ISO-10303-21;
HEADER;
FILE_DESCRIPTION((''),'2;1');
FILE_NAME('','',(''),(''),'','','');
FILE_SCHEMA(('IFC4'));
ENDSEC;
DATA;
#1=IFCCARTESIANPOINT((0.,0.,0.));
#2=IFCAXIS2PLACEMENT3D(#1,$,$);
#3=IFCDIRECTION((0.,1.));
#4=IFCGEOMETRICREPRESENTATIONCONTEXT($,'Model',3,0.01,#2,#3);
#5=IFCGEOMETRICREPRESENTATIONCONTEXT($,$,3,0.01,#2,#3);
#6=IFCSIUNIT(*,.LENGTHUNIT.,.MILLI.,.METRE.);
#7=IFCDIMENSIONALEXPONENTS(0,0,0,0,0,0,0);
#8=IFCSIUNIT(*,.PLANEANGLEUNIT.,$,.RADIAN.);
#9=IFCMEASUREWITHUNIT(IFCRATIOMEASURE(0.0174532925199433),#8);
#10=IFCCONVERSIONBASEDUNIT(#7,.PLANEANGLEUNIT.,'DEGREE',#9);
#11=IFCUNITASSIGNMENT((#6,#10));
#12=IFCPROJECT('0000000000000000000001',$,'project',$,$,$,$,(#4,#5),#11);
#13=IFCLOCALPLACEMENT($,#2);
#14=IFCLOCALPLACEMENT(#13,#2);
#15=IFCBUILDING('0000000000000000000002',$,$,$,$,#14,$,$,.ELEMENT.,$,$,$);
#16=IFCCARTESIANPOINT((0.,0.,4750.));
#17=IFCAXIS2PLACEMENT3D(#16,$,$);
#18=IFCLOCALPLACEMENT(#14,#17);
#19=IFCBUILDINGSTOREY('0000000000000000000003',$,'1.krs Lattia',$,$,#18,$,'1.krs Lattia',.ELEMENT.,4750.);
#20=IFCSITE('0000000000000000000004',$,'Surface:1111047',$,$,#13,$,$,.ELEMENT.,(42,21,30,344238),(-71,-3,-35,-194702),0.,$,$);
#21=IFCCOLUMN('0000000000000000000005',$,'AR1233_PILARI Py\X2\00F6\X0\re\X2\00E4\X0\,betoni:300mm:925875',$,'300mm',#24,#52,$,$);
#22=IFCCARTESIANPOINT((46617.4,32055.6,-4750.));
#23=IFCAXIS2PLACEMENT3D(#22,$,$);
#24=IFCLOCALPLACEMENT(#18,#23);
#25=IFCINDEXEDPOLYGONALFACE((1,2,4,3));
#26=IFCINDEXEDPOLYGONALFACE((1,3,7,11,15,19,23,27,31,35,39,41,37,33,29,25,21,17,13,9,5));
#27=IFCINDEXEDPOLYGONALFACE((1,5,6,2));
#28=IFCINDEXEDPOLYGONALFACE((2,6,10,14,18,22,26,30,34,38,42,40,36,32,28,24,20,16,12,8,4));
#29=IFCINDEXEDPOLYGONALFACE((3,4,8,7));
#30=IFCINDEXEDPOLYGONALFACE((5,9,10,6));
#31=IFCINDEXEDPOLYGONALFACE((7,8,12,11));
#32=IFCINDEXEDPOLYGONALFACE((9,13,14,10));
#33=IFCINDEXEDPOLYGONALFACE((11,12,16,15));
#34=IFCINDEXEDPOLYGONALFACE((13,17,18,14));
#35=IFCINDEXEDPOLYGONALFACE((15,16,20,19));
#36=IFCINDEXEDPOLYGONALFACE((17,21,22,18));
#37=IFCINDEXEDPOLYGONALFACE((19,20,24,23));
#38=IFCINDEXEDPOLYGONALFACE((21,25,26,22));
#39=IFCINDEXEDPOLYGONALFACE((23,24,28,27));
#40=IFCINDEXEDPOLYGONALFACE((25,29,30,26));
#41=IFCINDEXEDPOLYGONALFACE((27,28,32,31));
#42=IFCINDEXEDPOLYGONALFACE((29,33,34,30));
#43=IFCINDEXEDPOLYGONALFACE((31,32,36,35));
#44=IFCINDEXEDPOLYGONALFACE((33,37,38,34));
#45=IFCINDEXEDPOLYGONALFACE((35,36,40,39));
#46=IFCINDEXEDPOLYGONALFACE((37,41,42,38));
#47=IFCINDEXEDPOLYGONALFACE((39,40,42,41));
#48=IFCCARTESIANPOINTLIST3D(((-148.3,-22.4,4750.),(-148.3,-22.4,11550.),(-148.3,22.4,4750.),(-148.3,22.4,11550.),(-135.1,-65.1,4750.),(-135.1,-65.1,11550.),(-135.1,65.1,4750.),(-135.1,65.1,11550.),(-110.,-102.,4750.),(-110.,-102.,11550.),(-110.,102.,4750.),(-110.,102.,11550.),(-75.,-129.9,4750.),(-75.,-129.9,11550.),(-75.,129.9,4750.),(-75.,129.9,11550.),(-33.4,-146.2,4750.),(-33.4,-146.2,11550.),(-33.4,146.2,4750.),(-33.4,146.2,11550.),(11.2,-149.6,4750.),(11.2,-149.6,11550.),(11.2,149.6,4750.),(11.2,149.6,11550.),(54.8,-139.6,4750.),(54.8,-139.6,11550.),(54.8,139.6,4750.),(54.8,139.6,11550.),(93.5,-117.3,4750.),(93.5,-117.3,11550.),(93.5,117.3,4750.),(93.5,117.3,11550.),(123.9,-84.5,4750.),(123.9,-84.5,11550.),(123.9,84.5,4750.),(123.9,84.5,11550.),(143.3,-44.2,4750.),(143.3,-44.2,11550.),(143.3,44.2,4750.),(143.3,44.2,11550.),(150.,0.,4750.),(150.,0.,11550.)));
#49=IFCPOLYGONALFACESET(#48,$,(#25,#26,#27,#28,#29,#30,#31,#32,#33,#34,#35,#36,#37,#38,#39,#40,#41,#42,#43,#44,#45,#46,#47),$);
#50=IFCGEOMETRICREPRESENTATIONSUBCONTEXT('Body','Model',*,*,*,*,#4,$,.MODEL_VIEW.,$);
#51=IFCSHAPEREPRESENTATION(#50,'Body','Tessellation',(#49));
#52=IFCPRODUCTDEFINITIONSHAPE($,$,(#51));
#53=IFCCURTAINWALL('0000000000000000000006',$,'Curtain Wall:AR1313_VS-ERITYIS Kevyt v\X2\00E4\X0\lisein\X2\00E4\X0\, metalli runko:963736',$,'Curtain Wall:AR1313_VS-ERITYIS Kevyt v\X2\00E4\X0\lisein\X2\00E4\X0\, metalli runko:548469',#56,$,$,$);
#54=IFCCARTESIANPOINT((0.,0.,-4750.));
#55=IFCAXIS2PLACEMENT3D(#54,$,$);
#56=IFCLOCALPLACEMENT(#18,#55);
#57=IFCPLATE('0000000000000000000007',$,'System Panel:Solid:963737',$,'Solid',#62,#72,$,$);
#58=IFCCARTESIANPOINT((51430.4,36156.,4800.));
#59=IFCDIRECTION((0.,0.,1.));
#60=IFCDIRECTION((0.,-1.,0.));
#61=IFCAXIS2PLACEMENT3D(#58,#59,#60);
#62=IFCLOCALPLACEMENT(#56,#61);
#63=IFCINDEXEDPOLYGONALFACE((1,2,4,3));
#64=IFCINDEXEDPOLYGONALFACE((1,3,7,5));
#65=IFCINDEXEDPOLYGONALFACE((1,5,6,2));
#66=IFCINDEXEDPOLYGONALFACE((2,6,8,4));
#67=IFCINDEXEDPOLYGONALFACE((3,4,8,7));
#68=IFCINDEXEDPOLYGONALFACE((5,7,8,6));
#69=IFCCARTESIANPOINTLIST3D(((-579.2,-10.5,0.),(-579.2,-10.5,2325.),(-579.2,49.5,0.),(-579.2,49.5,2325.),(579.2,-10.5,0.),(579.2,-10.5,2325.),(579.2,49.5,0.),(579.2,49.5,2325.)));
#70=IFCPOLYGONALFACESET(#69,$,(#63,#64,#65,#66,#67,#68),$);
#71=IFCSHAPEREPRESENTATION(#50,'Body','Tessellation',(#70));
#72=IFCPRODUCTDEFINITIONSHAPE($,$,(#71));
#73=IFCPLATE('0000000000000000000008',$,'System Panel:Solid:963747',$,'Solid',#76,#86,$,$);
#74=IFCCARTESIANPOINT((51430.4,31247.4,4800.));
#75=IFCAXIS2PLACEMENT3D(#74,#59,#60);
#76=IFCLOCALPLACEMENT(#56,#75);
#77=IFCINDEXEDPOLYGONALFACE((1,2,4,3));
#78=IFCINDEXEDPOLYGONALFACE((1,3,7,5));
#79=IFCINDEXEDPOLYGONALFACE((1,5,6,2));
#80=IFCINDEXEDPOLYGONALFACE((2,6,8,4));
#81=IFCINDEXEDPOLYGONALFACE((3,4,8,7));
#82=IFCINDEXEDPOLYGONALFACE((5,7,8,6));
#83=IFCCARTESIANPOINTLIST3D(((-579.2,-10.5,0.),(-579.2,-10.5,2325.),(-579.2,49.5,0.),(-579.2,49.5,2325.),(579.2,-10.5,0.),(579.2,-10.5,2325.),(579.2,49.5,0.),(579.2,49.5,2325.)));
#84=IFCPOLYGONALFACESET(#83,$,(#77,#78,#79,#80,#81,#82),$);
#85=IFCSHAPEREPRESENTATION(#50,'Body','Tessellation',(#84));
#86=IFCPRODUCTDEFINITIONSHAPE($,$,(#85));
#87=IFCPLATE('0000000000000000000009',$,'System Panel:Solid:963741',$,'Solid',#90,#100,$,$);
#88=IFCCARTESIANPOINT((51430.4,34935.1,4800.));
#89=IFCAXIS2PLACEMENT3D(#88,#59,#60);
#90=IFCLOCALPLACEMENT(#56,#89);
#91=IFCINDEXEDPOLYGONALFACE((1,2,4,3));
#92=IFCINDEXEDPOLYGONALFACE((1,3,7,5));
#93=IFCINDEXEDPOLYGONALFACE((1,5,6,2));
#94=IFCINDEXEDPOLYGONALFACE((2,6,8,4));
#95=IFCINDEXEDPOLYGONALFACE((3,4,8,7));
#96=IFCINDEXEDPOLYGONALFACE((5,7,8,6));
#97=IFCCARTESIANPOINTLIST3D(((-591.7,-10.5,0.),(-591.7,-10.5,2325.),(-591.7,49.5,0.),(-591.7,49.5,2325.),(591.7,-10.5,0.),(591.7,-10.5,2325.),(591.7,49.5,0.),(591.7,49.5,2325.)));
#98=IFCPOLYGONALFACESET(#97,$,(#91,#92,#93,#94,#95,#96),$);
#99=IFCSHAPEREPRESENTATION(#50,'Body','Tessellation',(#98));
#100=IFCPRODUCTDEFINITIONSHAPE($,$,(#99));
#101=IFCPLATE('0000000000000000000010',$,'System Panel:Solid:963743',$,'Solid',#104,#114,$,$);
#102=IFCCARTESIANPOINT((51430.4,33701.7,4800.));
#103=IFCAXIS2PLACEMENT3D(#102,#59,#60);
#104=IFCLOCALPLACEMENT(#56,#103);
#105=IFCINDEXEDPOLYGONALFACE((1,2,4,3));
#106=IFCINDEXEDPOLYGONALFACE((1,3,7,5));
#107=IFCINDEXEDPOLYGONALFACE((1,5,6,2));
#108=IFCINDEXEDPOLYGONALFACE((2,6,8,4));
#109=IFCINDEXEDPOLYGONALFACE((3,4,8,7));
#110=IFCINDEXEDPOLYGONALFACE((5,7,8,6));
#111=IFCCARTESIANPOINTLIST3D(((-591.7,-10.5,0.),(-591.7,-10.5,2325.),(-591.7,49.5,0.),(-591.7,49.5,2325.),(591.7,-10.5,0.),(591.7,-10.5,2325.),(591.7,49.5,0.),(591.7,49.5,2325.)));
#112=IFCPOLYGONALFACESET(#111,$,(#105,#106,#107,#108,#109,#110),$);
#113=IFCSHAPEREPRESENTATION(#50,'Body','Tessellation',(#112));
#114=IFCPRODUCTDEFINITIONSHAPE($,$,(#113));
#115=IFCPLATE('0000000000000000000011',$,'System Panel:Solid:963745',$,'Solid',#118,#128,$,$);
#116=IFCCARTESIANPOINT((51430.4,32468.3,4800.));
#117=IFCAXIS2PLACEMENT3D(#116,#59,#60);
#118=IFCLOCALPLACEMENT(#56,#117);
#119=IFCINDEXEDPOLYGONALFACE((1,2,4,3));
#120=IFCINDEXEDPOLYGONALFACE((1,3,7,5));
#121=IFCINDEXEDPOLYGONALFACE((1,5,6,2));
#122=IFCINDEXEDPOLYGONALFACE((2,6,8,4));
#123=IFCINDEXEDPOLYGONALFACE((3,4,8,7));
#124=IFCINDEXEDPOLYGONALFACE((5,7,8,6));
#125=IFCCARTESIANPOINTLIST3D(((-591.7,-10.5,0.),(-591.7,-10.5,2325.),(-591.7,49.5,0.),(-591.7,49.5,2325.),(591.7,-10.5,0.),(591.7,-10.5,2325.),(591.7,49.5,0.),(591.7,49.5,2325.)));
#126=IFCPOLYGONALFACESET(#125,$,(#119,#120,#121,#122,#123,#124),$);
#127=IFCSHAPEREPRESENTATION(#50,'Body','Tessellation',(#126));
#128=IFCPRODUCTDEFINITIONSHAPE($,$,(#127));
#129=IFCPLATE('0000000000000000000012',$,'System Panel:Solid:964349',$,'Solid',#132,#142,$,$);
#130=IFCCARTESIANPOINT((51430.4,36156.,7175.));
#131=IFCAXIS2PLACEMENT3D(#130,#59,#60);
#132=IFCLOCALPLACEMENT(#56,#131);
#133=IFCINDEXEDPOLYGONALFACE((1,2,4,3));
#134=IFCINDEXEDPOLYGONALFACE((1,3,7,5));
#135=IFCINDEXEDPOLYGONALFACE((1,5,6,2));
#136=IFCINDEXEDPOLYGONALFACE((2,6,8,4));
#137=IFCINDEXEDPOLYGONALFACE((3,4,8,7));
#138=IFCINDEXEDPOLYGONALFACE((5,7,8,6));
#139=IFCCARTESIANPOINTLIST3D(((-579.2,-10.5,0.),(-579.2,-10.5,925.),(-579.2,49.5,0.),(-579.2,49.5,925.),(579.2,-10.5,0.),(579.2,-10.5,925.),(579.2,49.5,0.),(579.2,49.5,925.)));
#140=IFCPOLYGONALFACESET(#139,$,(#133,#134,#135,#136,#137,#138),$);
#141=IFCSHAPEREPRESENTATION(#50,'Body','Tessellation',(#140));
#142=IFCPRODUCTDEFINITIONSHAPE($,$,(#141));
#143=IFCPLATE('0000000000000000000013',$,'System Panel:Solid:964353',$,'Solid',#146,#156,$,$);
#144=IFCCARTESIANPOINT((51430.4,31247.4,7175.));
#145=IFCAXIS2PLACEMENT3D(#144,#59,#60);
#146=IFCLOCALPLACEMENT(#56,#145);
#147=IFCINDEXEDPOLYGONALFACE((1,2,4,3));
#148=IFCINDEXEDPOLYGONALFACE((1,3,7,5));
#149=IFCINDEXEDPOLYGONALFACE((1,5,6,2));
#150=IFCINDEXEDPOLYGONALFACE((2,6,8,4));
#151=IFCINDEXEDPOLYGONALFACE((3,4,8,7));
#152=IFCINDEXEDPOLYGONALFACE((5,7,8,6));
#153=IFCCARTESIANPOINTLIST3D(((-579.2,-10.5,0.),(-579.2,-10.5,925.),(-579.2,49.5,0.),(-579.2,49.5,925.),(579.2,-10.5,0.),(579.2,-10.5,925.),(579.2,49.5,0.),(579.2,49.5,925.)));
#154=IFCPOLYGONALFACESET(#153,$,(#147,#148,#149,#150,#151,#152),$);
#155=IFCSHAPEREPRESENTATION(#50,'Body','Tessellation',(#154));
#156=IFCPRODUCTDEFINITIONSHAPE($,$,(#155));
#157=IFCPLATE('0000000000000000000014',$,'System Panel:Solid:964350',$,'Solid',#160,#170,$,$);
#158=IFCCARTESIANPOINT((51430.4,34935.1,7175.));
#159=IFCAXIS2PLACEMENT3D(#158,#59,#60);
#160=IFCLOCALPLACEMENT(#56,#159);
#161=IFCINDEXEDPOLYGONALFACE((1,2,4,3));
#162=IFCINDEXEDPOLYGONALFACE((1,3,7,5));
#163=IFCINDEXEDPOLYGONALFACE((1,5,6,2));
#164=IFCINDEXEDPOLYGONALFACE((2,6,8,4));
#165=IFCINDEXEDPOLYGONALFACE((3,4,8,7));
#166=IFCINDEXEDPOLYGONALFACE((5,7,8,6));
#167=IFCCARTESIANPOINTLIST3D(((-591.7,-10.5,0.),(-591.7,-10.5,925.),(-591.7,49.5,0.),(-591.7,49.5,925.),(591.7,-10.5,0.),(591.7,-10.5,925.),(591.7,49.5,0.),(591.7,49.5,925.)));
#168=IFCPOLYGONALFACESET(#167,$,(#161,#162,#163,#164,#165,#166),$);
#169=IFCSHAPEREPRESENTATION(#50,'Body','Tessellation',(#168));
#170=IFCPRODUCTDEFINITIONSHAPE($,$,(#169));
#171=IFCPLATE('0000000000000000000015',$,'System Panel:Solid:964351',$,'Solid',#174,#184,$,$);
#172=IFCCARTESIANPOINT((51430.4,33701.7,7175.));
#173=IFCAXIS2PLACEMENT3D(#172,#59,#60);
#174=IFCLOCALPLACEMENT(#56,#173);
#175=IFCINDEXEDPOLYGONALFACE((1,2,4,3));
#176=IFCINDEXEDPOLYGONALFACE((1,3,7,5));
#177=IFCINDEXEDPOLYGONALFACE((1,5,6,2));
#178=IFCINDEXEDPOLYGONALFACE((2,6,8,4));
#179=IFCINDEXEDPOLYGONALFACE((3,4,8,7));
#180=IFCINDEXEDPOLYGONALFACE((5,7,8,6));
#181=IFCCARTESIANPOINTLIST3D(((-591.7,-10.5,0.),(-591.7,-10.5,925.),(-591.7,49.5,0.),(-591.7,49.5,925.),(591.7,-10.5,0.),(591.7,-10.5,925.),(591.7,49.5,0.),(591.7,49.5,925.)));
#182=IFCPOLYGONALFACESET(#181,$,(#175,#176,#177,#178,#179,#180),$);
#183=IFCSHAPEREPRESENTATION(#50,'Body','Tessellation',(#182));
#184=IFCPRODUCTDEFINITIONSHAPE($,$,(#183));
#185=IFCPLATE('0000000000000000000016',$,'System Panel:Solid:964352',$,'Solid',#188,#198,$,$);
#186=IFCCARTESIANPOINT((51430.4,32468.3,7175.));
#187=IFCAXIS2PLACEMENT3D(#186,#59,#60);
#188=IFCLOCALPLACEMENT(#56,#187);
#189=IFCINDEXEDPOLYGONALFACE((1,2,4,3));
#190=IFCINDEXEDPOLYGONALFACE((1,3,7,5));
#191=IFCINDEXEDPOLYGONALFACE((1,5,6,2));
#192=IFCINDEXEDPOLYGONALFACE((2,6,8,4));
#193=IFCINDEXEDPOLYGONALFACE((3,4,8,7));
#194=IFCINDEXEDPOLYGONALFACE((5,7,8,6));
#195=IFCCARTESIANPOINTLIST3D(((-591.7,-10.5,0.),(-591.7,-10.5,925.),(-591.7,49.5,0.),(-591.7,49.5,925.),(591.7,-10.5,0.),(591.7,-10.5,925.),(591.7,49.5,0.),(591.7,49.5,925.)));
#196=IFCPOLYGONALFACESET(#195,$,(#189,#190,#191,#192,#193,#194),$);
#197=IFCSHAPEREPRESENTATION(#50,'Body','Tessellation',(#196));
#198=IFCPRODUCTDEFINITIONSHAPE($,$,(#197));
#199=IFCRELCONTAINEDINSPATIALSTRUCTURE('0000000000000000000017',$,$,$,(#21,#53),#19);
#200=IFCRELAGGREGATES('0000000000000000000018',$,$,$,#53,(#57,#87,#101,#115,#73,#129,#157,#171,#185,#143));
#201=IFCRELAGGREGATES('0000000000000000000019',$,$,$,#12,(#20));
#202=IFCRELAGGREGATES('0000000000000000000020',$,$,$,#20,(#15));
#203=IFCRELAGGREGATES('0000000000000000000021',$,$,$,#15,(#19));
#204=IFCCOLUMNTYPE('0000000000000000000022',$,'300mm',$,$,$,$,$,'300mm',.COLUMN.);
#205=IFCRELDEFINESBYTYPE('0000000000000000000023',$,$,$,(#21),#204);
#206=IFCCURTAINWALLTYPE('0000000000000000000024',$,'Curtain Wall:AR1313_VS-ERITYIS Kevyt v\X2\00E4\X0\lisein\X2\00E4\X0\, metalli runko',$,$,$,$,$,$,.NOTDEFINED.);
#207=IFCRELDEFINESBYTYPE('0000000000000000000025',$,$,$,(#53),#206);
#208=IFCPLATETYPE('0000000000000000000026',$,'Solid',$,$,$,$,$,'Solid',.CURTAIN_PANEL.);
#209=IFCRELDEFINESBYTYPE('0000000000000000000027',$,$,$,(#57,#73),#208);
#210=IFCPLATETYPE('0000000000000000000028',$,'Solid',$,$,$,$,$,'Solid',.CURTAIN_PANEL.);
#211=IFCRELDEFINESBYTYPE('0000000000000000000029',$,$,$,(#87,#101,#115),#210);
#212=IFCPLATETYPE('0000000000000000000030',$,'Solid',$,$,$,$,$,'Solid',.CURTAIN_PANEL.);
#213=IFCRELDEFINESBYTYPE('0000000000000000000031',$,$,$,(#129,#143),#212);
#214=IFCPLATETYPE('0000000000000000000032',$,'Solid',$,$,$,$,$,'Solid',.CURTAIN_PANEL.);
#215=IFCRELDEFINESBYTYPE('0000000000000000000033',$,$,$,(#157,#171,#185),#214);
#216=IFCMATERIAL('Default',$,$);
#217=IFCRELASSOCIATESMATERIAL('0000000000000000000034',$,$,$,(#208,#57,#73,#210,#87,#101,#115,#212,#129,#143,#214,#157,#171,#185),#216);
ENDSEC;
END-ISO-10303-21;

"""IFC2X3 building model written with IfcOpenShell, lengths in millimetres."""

from ifc_helpers import new_model, entity, si_unit, converted_unit, direction, frame, frame_2d, origin, origin_2d_with_axis, place, context, subcontext, project, spatial, rectangle, circle, extrude, source, transform, mapped, material, type_object, type_shapes, element, aggregate, save


model = new_model("IFC2X3")

# Units and contexts
model_context = context("Model", 3, precision=0.01, world=origin(), true_north=direction((0.0, 1.0)))
context_of_model = context(None, 3, precision=0.01, world=origin(), true_north=direction((0.0, 1.0)))
body_context = subcontext(model_context, "Body", "Model", "MODEL_VIEW")
ifc_project = project(units=[si_unit("LENGTHUNIT", "METRE", prefix="MILLI"), converted_unit("PLANEANGLEUNIT", "DEGREE", entity("IfcRatioMeasure", 0.0174532925199433), si_unit("PLANEANGLEUNIT", "RADIAN"), dimensions=[0, 0, 0, 0, 0, 0, 0])], contexts=[model_context, context_of_model])

# Site, building, storey
site_placement = place(None, origin())
site = spatial("IfcSite", under=ifc_project, at=site_placement, Name="Surface:1111047", CompositionType="ELEMENT", RefLatitude=(42, 21, 30, 344238), RefLongitude=(-71, -3, -35, -194702), RefElevation=0.0)
building_placement = place(site_placement, origin())
building = spatial("IfcBuilding", under=site, at=building_placement, CompositionType="ELEMENT")
storey_placement = place(building_placement, frame((0.0, 0.0, 4750.0)))
storey = spatial("IfcBuildingStorey", under=building, at=storey_placement, Name="1.krs Lattia", LongName="1.krs Lattia", CompositionType="ELEMENT", Elevation=4750.0)

# Column
column_type = type_object("IfcColumnType", Name="300mm", ElementType="300mm", PredefinedType="COLUMN")
shared_shape_1 = source(origin(), body_context, "Body", "SweptSolid", [
    extrude(circle(Radius=150.0, at=frame_2d((0.0, 0.0), x_axis=(1.0, 0.0))), frame((0.0, 0.0, 4750.0)), (0.0, 0.0, 1.0), 6800.0),
])
type_shapes(column_type, [shared_shape_1])
column_placement = place(storey_placement, frame((46617.4, 32055.6, -4750.0)))
element("IfcColumn", 1, at=column_placement, inside=storey, type_object=column_type, Name="AR1233_PILARI Pyöreä,betoni:300mm:925875", ObjectType="300mm", context=body_context, shape_type="MappedRepresentation", body=[
    mapped(shared_shape_1, transform((0.0, 0.0, 0.0), scale=1.0)),
])

# Curtain wall, plates
curtain_wall_type = type_object("IfcCurtainWallType", Name="Curtain Wall:AR1313_VS-ERITYIS Kevyt väliseinä, metalli runko", PredefinedType="NOTDEFINED")
curtain_wall_placement = place(storey_placement, frame((0.0, 0.0, -4750.0)))
curtain_wall = element("IfcCurtainWall", 2, at=curtain_wall_placement, inside=storey, type_object=curtain_wall_type, Name="Curtain Wall:AR1313_VS-ERITYIS Kevyt väliseinä, metalli runko:963736", ObjectType="Curtain Wall:AR1313_VS-ERITYIS Kevyt väliseinä, metalli runko:548469")
ifc_material_1 = material(Name="Default")
plate_type_1 = type_object("IfcPlateType", Name="Solid", ElementType="Solid", PredefinedType="CURTAIN_PANEL", material=ifc_material_1)
shared_shape_2 = source(origin(), body_context, "Body", "SweptSolid", [
    extrude(rectangle(XDim=60.0, YDim=1158.4, at=origin_2d_with_axis()), frame((0.0, 19.5, 0.0), z_axis=(0.0, 0.0, 1.0), x_axis=(0.0, 1.0, 0.0)), (0.0, 0.0, 1.0), 2325.0),
])
type_shapes(plate_type_1, [shared_shape_2])
plate_1_placement = place(curtain_wall_placement, frame((51430.4, 36156.0, 4800.0), z_axis=(0.0, 0.0, 1.0), x_axis=(0.0, -1.0, 0.0)))
plate_1 = element("IfcPlate", 3, at=plate_1_placement, type_object=plate_type_1, material=ifc_material_1, Name="System Panel:Solid:963737", ObjectType="Solid", context=body_context, shape_type="MappedRepresentation", body=[
    mapped(shared_shape_2, transform((0.0, 0.0, 0.0), scale=1.0)),
])
plate_2_placement = place(curtain_wall_placement, frame((51430.4, 31247.4, 4800.0), z_axis=(0.0, 0.0, 1.0), x_axis=(0.0, -1.0, 0.0)))
plate_2 = element("IfcPlate", 4, at=plate_2_placement, type_object=plate_type_1, material=ifc_material_1, Name="System Panel:Solid:963747", ObjectType="Solid", context=body_context, shape_type="MappedRepresentation", body=[
    mapped(shared_shape_2, transform((0.0, 0.0, 0.0), scale=1.0)),
])
plate_type_2 = type_object("IfcPlateType", Name="Solid", ElementType="Solid", PredefinedType="CURTAIN_PANEL", material=ifc_material_1)
shared_shape_3 = source(origin(), body_context, "Body", "SweptSolid", [
    extrude(rectangle(XDim=60.0, YDim=1183.4, at=origin_2d_with_axis()), frame((0.0, 19.5, 0.0), z_axis=(0.0, 0.0, 1.0), x_axis=(0.0, 1.0, 0.0)), (0.0, 0.0, 1.0), 2325.0),
])
type_shapes(plate_type_2, [shared_shape_3])
plate_3_placement = place(curtain_wall_placement, frame((51430.4, 34935.1, 4800.0), z_axis=(0.0, 0.0, 1.0), x_axis=(0.0, -1.0, 0.0)))
plate_3 = element("IfcPlate", 5, at=plate_3_placement, type_object=plate_type_2, material=ifc_material_1, Name="System Panel:Solid:963741", ObjectType="Solid", context=body_context, shape_type="MappedRepresentation", body=[
    mapped(shared_shape_3, transform((0.0, 0.0, 0.0), scale=1.0)),
])
plate_4_placement = place(curtain_wall_placement, frame((51430.4, 33701.7, 4800.0), z_axis=(0.0, 0.0, 1.0), x_axis=(0.0, -1.0, 0.0)))
plate_4 = element("IfcPlate", 6, at=plate_4_placement, type_object=plate_type_2, material=ifc_material_1, Name="System Panel:Solid:963743", ObjectType="Solid", context=body_context, shape_type="MappedRepresentation", body=[
    mapped(shared_shape_3, transform((0.0, 0.0, 0.0), scale=1.0)),
])
plate_5_placement = place(curtain_wall_placement, frame((51430.4, 32468.3, 4800.0), z_axis=(0.0, 0.0, 1.0), x_axis=(0.0, -1.0, 0.0)))
plate_5 = element("IfcPlate", 7, at=plate_5_placement, type_object=plate_type_2, material=ifc_material_1, Name="System Panel:Solid:963745", ObjectType="Solid", context=body_context, shape_type="MappedRepresentation", body=[
    mapped(shared_shape_3, transform((0.0, 0.0, 0.0), scale=1.0)),
])
plate_type_3 = type_object("IfcPlateType", Name="Solid", ElementType="Solid", PredefinedType="CURTAIN_PANEL", material=ifc_material_1)
shared_shape_4 = source(origin(), body_context, "Body", "SweptSolid", [
    extrude(rectangle(XDim=60.0, YDim=1158.4, at=origin_2d_with_axis()), frame((0.0, 19.5, 0.0), z_axis=(0.0, 0.0, 1.0), x_axis=(0.0, 1.0, 0.0)), (0.0, 0.0, 1.0), 925.0),
])
type_shapes(plate_type_3, [shared_shape_4])
plate_6_placement = place(curtain_wall_placement, frame((51430.4, 36156.0, 7175.0), z_axis=(0.0, 0.0, 1.0), x_axis=(0.0, -1.0, 0.0)))
plate_6 = element("IfcPlate", 8, at=plate_6_placement, type_object=plate_type_3, material=ifc_material_1, Name="System Panel:Solid:964349", ObjectType="Solid", context=body_context, shape_type="MappedRepresentation", body=[
    mapped(shared_shape_4, transform((0.0, 0.0, 0.0), scale=1.0)),
])
plate_7_placement = place(curtain_wall_placement, frame((51430.4, 31247.4, 7175.0), z_axis=(0.0, 0.0, 1.0), x_axis=(0.0, -1.0, 0.0)))
plate_7 = element("IfcPlate", 9, at=plate_7_placement, type_object=plate_type_3, material=ifc_material_1, Name="System Panel:Solid:964353", ObjectType="Solid", context=body_context, shape_type="MappedRepresentation", body=[
    mapped(shared_shape_4, transform((0.0, 0.0, 0.0), scale=1.0)),
])
plate_type_4 = type_object("IfcPlateType", Name="Solid", ElementType="Solid", PredefinedType="CURTAIN_PANEL", material=ifc_material_1)
shared_shape_5 = source(origin(), body_context, "Body", "SweptSolid", [
    extrude(rectangle(XDim=60.0, YDim=1183.4, at=origin_2d_with_axis()), frame((0.0, 19.5, 0.0), z_axis=(0.0, 0.0, 1.0), x_axis=(0.0, 1.0, 0.0)), (0.0, 0.0, 1.0), 925.0),
])
type_shapes(plate_type_4, [shared_shape_5])
plate_8_placement = place(curtain_wall_placement, frame((51430.4, 34935.1, 7175.0), z_axis=(0.0, 0.0, 1.0), x_axis=(0.0, -1.0, 0.0)))
plate_8 = element("IfcPlate", 10, at=plate_8_placement, type_object=plate_type_4, material=ifc_material_1, Name="System Panel:Solid:964350", ObjectType="Solid", context=body_context, shape_type="MappedRepresentation", body=[
    mapped(shared_shape_5, transform((0.0, 0.0, 0.0), scale=1.0)),
])
plate_9_placement = place(curtain_wall_placement, frame((51430.4, 33701.7, 7175.0), z_axis=(0.0, 0.0, 1.0), x_axis=(0.0, -1.0, 0.0)))
plate_9 = element("IfcPlate", 11, at=plate_9_placement, type_object=plate_type_4, material=ifc_material_1, Name="System Panel:Solid:964351", ObjectType="Solid", context=body_context, shape_type="MappedRepresentation", body=[
    mapped(shared_shape_5, transform((0.0, 0.0, 0.0), scale=1.0)),
])
plate_10_placement = place(curtain_wall_placement, frame((51430.4, 32468.3, 7175.0), z_axis=(0.0, 0.0, 1.0), x_axis=(0.0, -1.0, 0.0)))
plate_10 = element("IfcPlate", 12, at=plate_10_placement, type_object=plate_type_4, material=ifc_material_1, Name="System Panel:Solid:964352", ObjectType="Solid", context=body_context, shape_type="MappedRepresentation", body=[
    mapped(shared_shape_5, transform((0.0, 0.0, 0.0), scale=1.0)),
])
aggregate(curtain_wall, [plate_1, plate_3, plate_4, plate_5, plate_2, plate_6, plate_8, plate_9, plate_10, plate_7])

save(model, "model.ifc")
